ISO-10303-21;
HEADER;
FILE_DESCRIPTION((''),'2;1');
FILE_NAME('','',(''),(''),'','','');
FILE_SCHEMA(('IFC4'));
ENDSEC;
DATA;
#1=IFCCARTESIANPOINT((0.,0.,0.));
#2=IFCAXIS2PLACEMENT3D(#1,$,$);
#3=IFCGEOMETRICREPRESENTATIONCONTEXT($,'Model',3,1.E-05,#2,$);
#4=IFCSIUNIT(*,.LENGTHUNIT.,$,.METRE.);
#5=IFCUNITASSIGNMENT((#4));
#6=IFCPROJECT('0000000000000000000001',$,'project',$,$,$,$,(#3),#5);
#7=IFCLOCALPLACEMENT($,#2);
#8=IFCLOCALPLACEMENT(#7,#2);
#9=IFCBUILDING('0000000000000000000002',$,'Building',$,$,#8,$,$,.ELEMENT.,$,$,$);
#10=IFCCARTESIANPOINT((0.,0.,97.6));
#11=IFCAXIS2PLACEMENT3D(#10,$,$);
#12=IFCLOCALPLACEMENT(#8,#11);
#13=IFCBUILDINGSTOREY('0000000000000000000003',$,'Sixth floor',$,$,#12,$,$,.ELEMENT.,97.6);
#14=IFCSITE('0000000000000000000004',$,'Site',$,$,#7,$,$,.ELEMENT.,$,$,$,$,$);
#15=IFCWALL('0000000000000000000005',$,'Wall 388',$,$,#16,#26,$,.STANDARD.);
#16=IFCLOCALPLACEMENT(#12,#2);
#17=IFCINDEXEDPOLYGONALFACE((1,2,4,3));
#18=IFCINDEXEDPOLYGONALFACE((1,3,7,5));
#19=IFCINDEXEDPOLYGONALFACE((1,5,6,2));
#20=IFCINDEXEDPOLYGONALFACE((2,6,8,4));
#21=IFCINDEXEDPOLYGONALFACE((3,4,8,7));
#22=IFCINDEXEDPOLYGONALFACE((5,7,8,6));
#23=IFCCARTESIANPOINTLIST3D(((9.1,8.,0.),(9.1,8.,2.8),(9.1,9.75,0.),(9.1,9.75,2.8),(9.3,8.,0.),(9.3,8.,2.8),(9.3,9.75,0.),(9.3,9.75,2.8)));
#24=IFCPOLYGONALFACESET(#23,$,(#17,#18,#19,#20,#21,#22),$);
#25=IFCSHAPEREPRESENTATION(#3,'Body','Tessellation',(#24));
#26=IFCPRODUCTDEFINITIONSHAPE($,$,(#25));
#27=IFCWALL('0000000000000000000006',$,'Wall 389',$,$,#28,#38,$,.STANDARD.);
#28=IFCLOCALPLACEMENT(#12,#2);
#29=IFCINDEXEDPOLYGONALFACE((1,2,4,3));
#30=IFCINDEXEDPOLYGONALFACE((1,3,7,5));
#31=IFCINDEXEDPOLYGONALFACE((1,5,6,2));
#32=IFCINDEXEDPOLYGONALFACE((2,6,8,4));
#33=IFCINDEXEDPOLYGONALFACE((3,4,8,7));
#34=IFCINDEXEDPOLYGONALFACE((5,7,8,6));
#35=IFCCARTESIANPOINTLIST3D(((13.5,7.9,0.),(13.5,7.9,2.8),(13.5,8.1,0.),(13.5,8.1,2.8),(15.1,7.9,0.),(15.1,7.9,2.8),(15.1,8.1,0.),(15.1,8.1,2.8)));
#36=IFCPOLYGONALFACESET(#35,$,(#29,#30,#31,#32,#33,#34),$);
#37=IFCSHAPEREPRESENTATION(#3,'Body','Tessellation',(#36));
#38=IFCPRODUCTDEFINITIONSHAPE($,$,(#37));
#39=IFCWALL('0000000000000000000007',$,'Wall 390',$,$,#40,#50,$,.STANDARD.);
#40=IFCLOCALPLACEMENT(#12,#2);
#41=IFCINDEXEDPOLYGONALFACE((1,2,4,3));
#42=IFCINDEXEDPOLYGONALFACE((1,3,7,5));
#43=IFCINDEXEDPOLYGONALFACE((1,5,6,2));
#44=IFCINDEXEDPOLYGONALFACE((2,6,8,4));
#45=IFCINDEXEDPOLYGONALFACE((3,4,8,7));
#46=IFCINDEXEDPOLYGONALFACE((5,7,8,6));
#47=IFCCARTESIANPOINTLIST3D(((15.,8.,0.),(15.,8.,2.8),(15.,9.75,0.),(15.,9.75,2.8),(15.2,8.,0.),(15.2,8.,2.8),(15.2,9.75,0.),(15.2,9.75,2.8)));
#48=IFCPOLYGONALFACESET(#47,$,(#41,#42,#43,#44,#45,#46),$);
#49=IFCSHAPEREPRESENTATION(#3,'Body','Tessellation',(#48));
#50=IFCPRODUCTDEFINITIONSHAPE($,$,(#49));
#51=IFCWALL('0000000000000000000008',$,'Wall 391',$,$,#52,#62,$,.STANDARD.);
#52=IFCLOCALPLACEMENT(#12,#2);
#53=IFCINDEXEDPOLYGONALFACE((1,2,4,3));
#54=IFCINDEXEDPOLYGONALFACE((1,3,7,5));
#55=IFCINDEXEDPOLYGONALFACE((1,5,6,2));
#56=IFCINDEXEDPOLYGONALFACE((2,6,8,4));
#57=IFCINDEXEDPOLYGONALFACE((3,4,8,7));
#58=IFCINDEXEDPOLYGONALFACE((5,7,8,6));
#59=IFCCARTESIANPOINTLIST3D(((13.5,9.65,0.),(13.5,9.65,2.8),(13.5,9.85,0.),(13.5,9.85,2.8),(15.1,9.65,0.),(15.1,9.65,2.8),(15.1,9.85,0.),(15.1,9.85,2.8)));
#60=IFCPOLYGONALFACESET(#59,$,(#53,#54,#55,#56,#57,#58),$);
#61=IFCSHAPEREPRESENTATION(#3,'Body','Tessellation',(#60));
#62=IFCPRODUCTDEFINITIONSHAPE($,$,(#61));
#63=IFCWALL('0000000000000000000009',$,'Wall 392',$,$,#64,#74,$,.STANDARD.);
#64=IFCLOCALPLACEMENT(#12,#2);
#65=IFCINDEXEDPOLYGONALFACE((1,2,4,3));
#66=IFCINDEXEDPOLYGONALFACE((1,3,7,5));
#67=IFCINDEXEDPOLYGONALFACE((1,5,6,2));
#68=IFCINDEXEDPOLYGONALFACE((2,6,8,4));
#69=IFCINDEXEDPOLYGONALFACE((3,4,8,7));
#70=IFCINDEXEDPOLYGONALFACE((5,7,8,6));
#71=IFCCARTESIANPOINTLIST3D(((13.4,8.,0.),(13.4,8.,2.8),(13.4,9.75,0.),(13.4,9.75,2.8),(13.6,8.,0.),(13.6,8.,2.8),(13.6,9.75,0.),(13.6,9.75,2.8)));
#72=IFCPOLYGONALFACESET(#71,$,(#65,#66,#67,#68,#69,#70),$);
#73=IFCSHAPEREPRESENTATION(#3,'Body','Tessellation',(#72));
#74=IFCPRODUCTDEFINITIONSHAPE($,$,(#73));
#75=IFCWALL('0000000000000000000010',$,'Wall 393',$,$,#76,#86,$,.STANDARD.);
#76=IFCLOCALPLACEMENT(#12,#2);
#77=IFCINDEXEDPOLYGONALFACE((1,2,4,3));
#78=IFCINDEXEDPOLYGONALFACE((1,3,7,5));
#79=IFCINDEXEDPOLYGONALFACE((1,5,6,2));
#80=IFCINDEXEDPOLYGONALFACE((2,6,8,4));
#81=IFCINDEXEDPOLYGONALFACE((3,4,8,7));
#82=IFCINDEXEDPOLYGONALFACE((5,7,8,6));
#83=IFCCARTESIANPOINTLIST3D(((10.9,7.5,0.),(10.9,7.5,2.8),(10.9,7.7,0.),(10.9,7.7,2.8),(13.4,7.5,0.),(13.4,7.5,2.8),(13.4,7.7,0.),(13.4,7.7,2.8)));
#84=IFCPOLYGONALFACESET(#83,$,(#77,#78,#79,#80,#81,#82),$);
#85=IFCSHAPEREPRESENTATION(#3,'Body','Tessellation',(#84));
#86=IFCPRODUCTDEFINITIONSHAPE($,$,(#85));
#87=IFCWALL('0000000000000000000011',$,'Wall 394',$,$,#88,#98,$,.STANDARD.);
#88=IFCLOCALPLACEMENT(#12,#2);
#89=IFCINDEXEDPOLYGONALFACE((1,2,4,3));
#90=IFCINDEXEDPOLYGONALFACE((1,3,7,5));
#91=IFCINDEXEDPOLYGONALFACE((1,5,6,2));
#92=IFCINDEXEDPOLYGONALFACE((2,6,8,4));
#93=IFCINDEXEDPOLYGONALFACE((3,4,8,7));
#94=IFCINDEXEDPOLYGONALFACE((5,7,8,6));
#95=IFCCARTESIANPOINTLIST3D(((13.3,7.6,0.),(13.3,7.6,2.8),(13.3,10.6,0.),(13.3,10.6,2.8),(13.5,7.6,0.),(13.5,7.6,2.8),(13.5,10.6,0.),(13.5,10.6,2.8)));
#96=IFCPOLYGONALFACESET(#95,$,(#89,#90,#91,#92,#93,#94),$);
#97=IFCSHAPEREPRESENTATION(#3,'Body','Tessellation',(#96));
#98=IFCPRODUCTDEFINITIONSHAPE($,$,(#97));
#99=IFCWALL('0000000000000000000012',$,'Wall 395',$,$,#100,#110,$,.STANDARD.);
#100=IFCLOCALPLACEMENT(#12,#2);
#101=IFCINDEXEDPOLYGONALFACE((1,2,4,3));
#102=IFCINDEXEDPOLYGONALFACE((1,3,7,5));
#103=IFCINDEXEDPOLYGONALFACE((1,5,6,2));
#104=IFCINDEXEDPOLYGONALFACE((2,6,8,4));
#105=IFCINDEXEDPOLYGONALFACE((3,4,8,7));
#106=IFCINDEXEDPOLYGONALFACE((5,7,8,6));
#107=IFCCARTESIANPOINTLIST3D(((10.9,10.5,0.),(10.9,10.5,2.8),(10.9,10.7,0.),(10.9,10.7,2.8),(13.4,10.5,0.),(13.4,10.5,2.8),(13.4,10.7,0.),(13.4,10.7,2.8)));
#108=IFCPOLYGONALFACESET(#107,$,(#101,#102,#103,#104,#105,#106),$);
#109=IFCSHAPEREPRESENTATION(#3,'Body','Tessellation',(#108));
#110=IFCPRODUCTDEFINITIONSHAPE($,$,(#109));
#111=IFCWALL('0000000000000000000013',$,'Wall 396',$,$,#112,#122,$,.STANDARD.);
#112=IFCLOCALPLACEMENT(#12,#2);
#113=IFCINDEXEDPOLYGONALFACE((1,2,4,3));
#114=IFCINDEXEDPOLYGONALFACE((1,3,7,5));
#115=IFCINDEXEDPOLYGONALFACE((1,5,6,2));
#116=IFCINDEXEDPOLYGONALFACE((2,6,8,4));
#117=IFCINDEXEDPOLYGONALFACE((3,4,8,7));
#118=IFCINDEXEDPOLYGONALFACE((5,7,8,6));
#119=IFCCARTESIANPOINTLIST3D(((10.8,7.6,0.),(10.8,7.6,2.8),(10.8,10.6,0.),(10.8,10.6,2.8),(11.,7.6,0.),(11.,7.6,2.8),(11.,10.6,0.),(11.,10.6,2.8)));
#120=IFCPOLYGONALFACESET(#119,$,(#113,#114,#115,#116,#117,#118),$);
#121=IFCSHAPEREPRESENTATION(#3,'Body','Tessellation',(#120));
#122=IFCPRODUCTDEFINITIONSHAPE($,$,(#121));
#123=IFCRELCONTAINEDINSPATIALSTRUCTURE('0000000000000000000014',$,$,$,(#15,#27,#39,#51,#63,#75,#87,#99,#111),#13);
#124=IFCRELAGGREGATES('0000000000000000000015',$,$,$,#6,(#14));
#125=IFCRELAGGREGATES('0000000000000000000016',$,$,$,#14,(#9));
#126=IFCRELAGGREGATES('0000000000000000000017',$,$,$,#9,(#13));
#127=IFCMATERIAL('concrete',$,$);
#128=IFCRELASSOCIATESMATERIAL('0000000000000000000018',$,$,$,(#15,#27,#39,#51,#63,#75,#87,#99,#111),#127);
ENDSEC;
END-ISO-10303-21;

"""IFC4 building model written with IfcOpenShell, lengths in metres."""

from ifc_helpers import new_model, si_unit, frame, frame_2d, origin, place, context, project, spatial, rectangle, extrude, material, element, save


model = new_model("IFC4")

# Units and contexts
model_context = context("Model", 3, precision=1e-05, world=origin())
ifc_project = project(units=[si_unit("LENGTHUNIT", "METRE")], contexts=[model_context])

# Site, building, storey
site_placement = place(None, origin())
site = spatial("IfcSite", under=ifc_project, at=site_placement, Name="Site", CompositionType="ELEMENT")
building_placement = place(site_placement, origin())
building = spatial("IfcBuilding", under=site, at=building_placement, Name="Building", CompositionType="ELEMENT")
storey_placement = place(building_placement, frame((0.0, 0.0, 97.6)))
storey = spatial("IfcBuildingStorey", under=building, at=storey_placement, Name="Sixth floor", CompositionType="ELEMENT", Elevation=97.6)

# Shared definitions
ifc_material = material(Name="concrete")

# Walls
wall_1_placement = place(storey_placement, frame((9.2, 9.75, 0.0), z_axis=(0.0, 0.0, 1.0), x_axis=(0.0, -1.0, 0.0)))
element("IfcWall", 1, at=wall_1_placement, inside=storey, material=ifc_material, Name="Wall 388", PredefinedType="STANDARD", context=model_context, shape_type="SweptSolid", body=[
    extrude(rectangle(XDim=1.75, YDim=0.2, at=frame_2d((0.875, 0.0))), origin(), (0.0, 0.0, 1.0), 2.8),
])
wall_2_placement = place(storey_placement, frame((13.5, 8.0, 0.0), z_axis=(0.0, 0.0, 1.0), x_axis=(1.0, 0.0, 0.0)))
element("IfcWall", 2, at=wall_2_placement, inside=storey, material=ifc_material, Name="Wall 389", PredefinedType="STANDARD", context=model_context, shape_type="SweptSolid", body=[
    extrude(rectangle(XDim=1.6, YDim=0.2, at=frame_2d((0.8, 0.0))), origin(), (0.0, 0.0, 1.0), 2.8),
])
wall_3_placement = place(storey_placement, frame((15.1, 8.0, 0.0), z_axis=(0.0, 0.0, 1.0), x_axis=(0.0, 1.0, 0.0)))
element("IfcWall", 3, at=wall_3_placement, inside=storey, material=ifc_material, Name="Wall 390", PredefinedType="STANDARD", context=model_context, shape_type="SweptSolid", body=[
    extrude(rectangle(XDim=1.75, YDim=0.2, at=frame_2d((0.875, 0.0))), origin(), (0.0, 0.0, 1.0), 2.8),
])
wall_4_placement = place(storey_placement, frame((15.1, 9.75, 0.0), z_axis=(0.0, 0.0, 1.0), x_axis=(-1.0, 0.0, 0.0)))
element("IfcWall", 4, at=wall_4_placement, inside=storey, material=ifc_material, Name="Wall 391", PredefinedType="STANDARD", context=model_context, shape_type="SweptSolid", body=[
    extrude(rectangle(XDim=1.6, YDim=0.2, at=frame_2d((0.8, 0.0))), origin(), (0.0, 0.0, 1.0), 2.8),
])
wall_5_placement = place(storey_placement, frame((13.5, 9.75, 0.0), z_axis=(0.0, 0.0, 1.0), x_axis=(0.0, -1.0, 0.0)))
element("IfcWall", 5, at=wall_5_placement, inside=storey, material=ifc_material, Name="Wall 392", PredefinedType="STANDARD", context=model_context, shape_type="SweptSolid", body=[
    extrude(rectangle(XDim=1.75, YDim=0.2, at=frame_2d((0.875, 0.0))), origin(), (0.0, 0.0, 1.0), 2.8),
])
wall_6_placement = place(storey_placement, frame((10.9, 7.6, 0.0), z_axis=(0.0, 0.0, 1.0), x_axis=(1.0, 0.0, 0.0)))
element("IfcWall", 6, at=wall_6_placement, inside=storey, material=ifc_material, Name="Wall 393", PredefinedType="STANDARD", context=model_context, shape_type="SweptSolid", body=[
    extrude(rectangle(XDim=2.5, YDim=0.2, at=frame_2d((1.25, 0.0))), origin(), (0.0, 0.0, 1.0), 2.8),
])
wall_7_placement = place(storey_placement, frame((13.4, 7.6, 0.0), z_axis=(0.0, 0.0, 1.0), x_axis=(0.0, 1.0, 0.0)))
element("IfcWall", 7, at=wall_7_placement, inside=storey, material=ifc_material, Name="Wall 394", PredefinedType="STANDARD", context=model_context, shape_type="SweptSolid", body=[
    extrude(rectangle(XDim=3.0, YDim=0.2, at=frame_2d((1.5, 0.0))), origin(), (0.0, 0.0, 1.0), 2.8),
])
wall_8_placement = place(storey_placement, frame((13.4, 10.6, 0.0), z_axis=(0.0, 0.0, 1.0), x_axis=(-1.0, 0.0, 0.0)))
element("IfcWall", 8, at=wall_8_placement, inside=storey, material=ifc_material, Name="Wall 395", PredefinedType="STANDARD", context=model_context, shape_type="SweptSolid", body=[
    extrude(rectangle(XDim=2.5, YDim=0.2, at=frame_2d((1.25, 0.0))), origin(), (0.0, 0.0, 1.0), 2.8),
])
wall_9_placement = place(storey_placement, frame((10.9, 10.6, 0.0), z_axis=(0.0, 0.0, 1.0), x_axis=(0.0, -1.0, 0.0)))
element("IfcWall", 9, at=wall_9_placement, inside=storey, material=ifc_material, Name="Wall 396", PredefinedType="STANDARD", context=model_context, shape_type="SweptSolid", body=[
    extrude(rectangle(XDim=3.0, YDim=0.2, at=frame_2d((1.5, 0.0))), origin(), (0.0, 0.0, 1.0), 2.8),
])

save(model, "model.ifc")
